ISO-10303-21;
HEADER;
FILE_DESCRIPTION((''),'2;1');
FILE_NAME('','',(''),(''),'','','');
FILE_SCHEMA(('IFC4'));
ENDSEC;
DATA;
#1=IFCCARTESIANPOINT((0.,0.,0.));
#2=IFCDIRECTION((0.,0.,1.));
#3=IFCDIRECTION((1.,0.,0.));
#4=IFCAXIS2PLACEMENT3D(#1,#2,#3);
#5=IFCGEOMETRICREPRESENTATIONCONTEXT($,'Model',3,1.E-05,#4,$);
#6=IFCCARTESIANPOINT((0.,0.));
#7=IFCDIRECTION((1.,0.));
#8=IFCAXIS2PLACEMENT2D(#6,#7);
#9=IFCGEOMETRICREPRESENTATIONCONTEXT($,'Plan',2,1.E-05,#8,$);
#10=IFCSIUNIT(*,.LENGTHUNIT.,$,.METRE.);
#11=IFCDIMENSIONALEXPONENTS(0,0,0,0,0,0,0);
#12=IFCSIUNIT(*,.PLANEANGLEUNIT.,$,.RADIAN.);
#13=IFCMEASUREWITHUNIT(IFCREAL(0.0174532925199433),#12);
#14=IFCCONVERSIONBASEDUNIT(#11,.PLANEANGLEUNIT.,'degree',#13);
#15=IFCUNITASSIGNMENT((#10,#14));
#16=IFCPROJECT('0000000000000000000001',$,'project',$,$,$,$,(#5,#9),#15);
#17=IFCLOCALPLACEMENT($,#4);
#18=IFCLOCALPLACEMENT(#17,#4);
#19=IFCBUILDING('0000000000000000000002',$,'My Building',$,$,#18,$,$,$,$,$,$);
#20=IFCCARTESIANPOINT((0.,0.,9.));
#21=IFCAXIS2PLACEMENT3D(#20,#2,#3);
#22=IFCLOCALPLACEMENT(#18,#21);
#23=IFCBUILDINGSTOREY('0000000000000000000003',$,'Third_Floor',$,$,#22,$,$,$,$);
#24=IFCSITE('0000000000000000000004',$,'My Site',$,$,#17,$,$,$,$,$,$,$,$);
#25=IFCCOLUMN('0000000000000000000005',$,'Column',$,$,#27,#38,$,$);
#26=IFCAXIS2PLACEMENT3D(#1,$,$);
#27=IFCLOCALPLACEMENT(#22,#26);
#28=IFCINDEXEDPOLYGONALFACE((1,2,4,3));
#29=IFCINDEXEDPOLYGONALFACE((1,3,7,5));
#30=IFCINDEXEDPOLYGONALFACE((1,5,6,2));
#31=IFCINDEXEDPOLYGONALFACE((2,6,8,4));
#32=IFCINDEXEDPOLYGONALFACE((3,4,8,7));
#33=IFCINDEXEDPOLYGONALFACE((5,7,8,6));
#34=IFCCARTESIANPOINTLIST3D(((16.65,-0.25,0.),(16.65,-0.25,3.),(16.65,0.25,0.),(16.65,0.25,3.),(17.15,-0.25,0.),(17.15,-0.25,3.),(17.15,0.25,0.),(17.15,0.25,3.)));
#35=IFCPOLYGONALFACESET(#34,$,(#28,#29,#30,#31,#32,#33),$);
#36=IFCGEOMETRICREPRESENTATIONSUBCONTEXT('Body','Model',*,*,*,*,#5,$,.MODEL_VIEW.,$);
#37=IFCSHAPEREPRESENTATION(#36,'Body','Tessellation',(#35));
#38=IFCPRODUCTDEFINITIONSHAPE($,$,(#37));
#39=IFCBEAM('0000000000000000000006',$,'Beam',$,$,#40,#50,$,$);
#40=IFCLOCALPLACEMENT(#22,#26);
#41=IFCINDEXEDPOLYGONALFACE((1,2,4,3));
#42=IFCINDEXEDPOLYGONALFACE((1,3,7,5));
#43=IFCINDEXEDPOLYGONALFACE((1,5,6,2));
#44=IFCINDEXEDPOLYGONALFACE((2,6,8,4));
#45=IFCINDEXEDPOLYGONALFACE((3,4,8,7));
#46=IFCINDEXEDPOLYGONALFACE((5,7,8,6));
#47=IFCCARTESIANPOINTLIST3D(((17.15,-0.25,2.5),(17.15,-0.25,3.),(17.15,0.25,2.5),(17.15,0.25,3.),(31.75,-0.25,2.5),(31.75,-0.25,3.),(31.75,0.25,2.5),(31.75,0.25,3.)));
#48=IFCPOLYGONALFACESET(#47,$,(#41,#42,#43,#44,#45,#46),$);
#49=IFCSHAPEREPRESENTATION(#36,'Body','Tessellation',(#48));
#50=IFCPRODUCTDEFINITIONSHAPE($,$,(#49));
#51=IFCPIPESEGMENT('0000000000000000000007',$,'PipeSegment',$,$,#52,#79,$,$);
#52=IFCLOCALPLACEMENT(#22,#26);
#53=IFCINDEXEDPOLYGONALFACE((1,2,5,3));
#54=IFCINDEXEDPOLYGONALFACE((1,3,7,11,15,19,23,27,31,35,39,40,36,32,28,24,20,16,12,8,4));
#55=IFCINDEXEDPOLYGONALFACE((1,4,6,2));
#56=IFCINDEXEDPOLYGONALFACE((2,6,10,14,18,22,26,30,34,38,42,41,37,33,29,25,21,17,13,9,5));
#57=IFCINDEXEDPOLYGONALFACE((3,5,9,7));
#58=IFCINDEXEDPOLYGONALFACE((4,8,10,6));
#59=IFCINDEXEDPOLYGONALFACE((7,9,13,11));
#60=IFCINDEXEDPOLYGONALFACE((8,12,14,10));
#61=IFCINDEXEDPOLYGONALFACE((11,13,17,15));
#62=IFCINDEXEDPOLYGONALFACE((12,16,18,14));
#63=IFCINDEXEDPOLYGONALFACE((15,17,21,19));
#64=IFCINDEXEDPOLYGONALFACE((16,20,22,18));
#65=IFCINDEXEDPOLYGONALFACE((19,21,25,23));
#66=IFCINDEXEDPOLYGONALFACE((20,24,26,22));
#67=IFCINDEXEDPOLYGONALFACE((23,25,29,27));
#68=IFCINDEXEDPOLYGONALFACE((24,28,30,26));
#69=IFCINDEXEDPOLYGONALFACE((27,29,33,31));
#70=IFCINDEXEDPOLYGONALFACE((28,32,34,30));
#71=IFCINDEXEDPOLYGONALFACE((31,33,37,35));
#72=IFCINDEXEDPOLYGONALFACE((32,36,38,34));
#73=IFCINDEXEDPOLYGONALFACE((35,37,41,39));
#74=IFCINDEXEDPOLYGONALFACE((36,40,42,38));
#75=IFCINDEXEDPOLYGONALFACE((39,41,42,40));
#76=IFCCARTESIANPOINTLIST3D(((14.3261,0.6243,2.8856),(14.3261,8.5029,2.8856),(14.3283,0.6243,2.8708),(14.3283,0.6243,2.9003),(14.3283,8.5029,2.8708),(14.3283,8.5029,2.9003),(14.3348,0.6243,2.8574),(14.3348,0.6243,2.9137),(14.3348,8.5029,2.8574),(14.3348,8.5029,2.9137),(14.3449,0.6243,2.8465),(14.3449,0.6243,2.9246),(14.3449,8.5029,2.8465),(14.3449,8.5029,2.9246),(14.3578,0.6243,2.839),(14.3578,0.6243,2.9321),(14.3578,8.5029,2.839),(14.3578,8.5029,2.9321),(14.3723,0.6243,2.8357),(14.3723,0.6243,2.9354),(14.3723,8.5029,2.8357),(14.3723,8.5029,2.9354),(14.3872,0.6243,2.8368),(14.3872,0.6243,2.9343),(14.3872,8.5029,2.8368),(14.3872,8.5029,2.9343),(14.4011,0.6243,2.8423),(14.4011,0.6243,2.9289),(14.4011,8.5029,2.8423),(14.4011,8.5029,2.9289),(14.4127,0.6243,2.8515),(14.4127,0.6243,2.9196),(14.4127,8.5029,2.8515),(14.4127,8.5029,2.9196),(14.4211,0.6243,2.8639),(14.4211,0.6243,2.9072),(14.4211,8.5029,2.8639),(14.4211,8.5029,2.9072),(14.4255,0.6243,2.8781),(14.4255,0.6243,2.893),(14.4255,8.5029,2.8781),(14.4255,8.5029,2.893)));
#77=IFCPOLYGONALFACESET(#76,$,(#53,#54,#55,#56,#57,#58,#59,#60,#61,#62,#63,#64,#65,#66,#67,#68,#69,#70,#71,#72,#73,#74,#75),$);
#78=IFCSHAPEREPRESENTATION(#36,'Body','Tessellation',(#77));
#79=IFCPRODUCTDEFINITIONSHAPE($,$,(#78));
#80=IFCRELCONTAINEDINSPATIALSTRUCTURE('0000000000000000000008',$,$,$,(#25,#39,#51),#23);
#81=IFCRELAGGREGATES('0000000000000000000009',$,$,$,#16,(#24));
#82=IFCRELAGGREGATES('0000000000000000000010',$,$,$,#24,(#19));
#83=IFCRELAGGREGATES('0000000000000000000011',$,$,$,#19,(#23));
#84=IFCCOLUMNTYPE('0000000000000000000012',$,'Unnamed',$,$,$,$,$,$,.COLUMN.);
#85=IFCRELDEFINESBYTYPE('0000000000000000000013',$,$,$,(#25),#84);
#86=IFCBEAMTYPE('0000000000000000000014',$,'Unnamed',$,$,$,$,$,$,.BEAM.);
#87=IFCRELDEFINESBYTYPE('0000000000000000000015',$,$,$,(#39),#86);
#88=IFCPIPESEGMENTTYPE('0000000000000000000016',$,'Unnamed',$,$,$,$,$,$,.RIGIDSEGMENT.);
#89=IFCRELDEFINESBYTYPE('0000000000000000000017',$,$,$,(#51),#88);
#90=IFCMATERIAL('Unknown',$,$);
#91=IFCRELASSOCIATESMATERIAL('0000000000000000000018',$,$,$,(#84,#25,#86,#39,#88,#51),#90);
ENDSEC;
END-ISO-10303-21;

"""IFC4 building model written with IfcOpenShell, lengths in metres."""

from ifc_helpers import new_model, entity, si_unit, converted_unit, frame, origin_with_axes, origin_2d_with_axis, place, context, subcontext, project, spatial, rectangle, circle, extrude, material, material_profile, profile_set, profile_usage, type_object, element, save


model = new_model("IFC4")

# Units and contexts
model_context = context("Model", 3, precision=1e-05, world=origin_with_axes())
plan_context = context("Plan", 2, precision=1e-05, world=origin_2d_with_axis())
body_context = subcontext(model_context, "Body", "Model", "MODEL_VIEW")
ifc_project = project(units=[si_unit("LENGTHUNIT", "METRE"), converted_unit("PLANEANGLEUNIT", "degree", entity("IfcReal", 0.0174532925199433), si_unit("PLANEANGLEUNIT", "RADIAN"), dimensions=[0, 0, 0, 0, 0, 0, 0])], contexts=[model_context, plan_context])

# Site, building, storey
site_placement = place(None, origin_with_axes())
site = spatial("IfcSite", under=ifc_project, at=site_placement, Name="My Site")
building_placement = place(site_placement, origin_with_axes())
building = spatial("IfcBuilding", under=site, at=building_placement, Name="My Building")
storey_placement = place(building_placement, frame((0.0, 0.0, 9.0), z_axis=(0.0, 0.0, 1.0), x_axis=(1.0, 0.0, 0.0)))
storey = spatial("IfcBuildingStorey", under=building, at=storey_placement, Name="Third_Floor")

# Column
ifc_material = material(Name="Unknown")
ifc_material_profile_1 = material_profile(ifc_material, rectangle(XDim=0.5, YDim=0.5))
ifc_profile_set_1 = profile_set([ifc_material_profile_1])
ifc_profile_usage_1 = profile_usage(ifc_profile_set_1, cardinal=5)
column_type = type_object("IfcColumnType", Name="Unnamed", PredefinedType="COLUMN", material=ifc_profile_set_1)
column_placement = place(storey_placement, frame((16.9, 0.0, 0.0), z_axis=(0.0, 0.0, 1.0), x_axis=(1.0, 0.0, 0.0)))
element("IfcColumn", 1, at=column_placement, inside=storey, type_object=column_type, material=ifc_profile_usage_1, Name="Column", context=body_context, shape_type="SweptSolid", body=[
    extrude(rectangle(XDim=0.5, YDim=0.5), origin_with_axes(), (0.0, 0.0, 1.0), 3.0),
])

# Beam
ifc_material_profile_2 = material_profile(ifc_material, rectangle(XDim=0.5, YDim=0.5))
ifc_profile_set_2 = profile_set([ifc_material_profile_2])
ifc_profile_usage_2 = profile_usage(ifc_profile_set_2, cardinal=6)
beam_type = type_object("IfcBeamType", Name="Unnamed", PredefinedType="BEAM", material=ifc_profile_set_2)
beam_placement = place(storey_placement, frame((17.15, -0.25, 2.75), z_axis=(1.0, 0.0, 0.0), x_axis=(0.0, 1.0, 0.0)))
element("IfcBeam", 2, at=beam_placement, inside=storey, type_object=beam_type, material=ifc_profile_usage_2, Name="Beam", context=body_context, shape_type="SweptSolid", body=[
    extrude(rectangle(XDim=0.5, YDim=0.5), frame((0.25, 0.0, 0.0), z_axis=(0.0, 0.0, 1.0), x_axis=(1.0, 0.0, 0.0)), (0.0, 0.0, 1.0), 14.6),
])

# Pipe segment
ifc_material_profile_3 = material_profile(ifc_material, circle(Radius=0.05))
ifc_profile_set_3 = profile_set([ifc_material_profile_3])
ifc_profile_usage_3 = profile_usage(ifc_profile_set_3, cardinal=5)
pipe_segment_type = type_object("IfcPipeSegmentType", Name="Unnamed", PredefinedType="RIGIDSEGMENT", material=ifc_profile_set_3)
pipe_segment_placement = place(storey_placement, frame((14.3761, 0.6243, 2.8856), z_axis=(0.0, 1.0, 0.0), x_axis=(-1.0, 0.0, 0.0)))
element("IfcPipeSegment", 3, at=pipe_segment_placement, inside=storey, type_object=pipe_segment_type, material=ifc_profile_usage_3, Name="PipeSegment", context=body_context, shape_type="SweptSolid", body=[
    extrude(circle(Radius=0.05), origin_with_axes(), (0.0, 0.0, 1.0), 7.8786),
])

save(model, "model.ifc")
